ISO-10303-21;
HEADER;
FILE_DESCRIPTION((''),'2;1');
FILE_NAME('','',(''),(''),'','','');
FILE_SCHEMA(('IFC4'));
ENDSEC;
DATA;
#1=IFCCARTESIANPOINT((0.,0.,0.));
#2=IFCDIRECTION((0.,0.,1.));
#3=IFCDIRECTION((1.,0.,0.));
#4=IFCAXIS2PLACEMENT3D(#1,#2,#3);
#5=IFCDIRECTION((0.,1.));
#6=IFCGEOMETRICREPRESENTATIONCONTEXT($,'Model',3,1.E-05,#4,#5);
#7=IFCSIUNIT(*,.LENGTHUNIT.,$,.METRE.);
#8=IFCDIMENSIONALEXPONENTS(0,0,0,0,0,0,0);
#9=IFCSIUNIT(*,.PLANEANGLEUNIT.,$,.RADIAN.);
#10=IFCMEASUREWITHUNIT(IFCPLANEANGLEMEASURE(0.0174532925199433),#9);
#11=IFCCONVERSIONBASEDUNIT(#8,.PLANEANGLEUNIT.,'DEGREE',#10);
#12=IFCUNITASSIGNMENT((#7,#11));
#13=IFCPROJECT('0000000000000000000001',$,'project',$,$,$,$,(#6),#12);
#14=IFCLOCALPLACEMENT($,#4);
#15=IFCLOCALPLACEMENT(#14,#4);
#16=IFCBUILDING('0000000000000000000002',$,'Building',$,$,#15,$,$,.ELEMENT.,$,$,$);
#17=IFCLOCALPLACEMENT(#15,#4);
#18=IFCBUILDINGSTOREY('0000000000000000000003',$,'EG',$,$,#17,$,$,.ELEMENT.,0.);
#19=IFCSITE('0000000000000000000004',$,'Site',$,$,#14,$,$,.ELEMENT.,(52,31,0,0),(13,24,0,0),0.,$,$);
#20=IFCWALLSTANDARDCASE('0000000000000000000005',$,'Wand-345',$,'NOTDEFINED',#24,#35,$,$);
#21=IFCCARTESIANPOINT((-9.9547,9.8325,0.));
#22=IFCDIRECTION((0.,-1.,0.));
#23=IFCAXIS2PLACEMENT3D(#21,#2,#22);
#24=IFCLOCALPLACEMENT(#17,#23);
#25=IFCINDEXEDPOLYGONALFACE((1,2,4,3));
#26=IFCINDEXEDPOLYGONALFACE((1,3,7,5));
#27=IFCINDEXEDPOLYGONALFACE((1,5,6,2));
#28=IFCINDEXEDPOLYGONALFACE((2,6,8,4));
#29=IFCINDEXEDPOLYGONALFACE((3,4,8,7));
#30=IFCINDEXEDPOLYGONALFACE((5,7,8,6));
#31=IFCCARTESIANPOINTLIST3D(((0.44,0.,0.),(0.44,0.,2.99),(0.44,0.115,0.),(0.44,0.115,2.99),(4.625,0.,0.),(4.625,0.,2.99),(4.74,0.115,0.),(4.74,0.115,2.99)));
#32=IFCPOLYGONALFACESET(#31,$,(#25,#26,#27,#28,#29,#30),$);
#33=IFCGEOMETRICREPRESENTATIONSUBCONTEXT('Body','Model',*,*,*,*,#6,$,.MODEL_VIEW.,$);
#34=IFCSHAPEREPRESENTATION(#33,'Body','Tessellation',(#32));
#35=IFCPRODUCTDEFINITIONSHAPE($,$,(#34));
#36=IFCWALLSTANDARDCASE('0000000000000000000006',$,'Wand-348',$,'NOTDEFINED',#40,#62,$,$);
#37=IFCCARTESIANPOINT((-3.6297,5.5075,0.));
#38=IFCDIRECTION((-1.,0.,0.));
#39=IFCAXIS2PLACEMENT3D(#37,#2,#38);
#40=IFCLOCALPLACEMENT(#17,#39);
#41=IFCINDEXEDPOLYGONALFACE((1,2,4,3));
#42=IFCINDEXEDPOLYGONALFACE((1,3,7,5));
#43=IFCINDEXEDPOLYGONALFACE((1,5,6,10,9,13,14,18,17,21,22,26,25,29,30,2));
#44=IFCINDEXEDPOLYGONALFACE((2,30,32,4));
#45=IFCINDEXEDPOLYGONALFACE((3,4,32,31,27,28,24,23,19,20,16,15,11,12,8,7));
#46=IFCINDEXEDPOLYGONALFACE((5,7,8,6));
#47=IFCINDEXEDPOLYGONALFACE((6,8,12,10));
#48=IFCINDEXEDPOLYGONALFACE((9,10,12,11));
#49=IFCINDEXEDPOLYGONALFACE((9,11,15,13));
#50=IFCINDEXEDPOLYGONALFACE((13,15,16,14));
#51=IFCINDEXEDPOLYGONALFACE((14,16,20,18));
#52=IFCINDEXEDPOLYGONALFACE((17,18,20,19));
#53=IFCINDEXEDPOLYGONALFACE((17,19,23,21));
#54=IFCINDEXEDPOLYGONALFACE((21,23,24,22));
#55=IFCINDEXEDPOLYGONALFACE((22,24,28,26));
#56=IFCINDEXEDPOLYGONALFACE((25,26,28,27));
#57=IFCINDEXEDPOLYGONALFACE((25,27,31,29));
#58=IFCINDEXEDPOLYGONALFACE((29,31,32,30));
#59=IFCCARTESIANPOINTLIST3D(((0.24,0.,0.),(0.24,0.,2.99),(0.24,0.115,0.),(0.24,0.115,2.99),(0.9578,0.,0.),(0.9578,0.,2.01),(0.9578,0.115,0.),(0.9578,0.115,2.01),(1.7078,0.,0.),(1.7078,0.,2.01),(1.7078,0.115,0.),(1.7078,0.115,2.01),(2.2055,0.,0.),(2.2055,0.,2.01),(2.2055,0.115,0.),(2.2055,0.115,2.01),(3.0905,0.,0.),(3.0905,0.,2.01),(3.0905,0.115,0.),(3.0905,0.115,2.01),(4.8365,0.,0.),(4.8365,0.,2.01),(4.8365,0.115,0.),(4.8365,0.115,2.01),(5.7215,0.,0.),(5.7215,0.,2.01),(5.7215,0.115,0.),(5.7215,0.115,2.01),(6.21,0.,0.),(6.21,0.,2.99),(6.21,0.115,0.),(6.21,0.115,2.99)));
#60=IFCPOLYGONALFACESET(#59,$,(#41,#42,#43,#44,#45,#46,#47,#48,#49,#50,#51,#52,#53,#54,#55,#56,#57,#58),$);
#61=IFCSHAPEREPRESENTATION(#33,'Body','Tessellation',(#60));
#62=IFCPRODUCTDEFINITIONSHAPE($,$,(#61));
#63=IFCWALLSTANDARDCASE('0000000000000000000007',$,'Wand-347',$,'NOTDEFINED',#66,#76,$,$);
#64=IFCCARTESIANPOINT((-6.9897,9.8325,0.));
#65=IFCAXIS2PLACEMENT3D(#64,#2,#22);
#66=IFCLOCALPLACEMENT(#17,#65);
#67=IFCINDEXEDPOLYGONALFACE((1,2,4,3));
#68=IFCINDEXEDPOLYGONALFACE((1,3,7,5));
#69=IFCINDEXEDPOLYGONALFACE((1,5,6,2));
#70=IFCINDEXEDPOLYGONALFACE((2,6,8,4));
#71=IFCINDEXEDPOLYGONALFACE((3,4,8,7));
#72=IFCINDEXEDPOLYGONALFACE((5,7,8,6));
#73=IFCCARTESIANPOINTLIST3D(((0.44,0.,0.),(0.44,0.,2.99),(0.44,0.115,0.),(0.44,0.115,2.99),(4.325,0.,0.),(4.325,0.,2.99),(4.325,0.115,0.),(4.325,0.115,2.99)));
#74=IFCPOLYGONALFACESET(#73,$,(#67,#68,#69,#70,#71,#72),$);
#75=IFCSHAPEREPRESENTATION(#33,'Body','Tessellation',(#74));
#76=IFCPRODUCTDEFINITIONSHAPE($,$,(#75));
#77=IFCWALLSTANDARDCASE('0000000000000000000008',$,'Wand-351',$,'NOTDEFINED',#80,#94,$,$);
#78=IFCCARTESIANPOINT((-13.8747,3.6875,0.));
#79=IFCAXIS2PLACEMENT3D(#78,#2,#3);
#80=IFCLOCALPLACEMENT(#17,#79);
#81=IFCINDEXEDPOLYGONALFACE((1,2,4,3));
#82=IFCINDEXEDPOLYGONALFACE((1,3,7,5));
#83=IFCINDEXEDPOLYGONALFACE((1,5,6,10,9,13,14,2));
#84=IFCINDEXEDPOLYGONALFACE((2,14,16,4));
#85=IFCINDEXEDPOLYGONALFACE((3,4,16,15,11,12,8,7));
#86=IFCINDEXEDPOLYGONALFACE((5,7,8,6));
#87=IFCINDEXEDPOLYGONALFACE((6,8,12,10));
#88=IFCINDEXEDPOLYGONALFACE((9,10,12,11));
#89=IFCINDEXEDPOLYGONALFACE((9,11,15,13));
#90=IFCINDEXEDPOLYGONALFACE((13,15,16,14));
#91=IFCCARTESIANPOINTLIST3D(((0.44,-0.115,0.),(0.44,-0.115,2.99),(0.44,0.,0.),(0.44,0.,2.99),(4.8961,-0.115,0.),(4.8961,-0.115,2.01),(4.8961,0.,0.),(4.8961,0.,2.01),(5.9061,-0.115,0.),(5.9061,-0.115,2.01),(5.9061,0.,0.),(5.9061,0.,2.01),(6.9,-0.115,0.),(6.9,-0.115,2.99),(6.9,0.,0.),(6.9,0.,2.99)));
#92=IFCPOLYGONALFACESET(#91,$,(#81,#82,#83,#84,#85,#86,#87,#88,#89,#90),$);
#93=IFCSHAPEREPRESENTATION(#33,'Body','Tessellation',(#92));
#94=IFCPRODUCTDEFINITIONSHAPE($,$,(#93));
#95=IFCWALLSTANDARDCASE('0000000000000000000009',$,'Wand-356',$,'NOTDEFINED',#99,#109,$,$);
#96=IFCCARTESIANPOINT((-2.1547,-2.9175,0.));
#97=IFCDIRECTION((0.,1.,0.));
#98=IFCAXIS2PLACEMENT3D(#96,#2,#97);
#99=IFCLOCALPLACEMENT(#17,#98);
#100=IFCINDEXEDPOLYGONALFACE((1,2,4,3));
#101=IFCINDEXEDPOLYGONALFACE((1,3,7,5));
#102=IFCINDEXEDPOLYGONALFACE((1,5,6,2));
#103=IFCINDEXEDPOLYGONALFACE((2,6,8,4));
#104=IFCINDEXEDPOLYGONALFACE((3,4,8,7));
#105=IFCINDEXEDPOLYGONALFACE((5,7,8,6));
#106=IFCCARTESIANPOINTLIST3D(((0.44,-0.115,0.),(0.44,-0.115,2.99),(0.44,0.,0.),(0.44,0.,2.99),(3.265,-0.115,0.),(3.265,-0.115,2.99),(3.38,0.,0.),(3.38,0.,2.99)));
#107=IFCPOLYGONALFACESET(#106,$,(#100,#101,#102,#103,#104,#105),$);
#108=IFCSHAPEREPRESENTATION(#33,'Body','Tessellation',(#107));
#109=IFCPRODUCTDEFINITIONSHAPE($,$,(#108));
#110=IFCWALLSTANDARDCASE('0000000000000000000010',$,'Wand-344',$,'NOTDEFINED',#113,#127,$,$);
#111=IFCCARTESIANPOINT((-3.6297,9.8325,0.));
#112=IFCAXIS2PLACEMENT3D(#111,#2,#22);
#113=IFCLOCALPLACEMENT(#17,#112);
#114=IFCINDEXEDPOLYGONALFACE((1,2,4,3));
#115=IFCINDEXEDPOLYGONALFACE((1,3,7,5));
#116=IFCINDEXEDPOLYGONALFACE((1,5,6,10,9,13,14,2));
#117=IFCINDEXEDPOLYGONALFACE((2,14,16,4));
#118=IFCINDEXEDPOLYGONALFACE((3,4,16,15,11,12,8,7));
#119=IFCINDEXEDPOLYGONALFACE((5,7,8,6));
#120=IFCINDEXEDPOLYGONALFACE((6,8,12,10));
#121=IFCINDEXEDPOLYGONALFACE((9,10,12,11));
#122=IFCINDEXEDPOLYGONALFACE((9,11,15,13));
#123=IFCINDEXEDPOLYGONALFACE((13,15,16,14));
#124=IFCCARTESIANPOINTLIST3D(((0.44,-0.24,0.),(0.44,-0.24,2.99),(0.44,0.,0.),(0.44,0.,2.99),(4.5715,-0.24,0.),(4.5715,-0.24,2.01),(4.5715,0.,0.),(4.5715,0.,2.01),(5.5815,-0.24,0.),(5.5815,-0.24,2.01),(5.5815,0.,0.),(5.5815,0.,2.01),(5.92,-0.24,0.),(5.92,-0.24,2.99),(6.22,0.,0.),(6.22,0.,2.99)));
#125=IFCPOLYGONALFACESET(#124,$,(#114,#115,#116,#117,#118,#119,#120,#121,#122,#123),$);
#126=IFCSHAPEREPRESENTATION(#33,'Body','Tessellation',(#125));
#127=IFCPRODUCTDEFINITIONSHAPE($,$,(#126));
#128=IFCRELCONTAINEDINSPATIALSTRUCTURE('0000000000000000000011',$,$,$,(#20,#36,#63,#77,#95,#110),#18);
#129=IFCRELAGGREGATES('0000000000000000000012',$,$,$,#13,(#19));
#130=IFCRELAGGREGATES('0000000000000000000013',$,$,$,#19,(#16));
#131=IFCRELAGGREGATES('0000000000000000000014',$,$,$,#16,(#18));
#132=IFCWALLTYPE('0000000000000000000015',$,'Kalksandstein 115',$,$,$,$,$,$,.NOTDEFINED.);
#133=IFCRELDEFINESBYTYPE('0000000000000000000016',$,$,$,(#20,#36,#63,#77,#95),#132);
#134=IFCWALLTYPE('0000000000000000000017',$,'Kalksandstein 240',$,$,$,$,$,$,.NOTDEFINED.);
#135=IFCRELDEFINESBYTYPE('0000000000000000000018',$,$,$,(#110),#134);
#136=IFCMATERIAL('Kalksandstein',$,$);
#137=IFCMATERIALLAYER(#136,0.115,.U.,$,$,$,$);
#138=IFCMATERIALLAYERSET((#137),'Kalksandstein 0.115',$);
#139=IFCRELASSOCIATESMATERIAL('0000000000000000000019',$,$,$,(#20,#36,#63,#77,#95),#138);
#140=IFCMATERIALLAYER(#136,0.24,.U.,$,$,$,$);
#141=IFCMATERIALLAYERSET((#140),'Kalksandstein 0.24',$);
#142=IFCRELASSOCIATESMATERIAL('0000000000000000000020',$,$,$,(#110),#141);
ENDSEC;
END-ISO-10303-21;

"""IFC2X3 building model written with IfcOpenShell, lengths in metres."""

from ifc_helpers import new_model, entity, si_unit, converted_unit, direction, frame, origin_with_axes, origin_2d_with_axis, place, context, subcontext, project, spatial, polyline, rectangle, outline, extrude, material, layer, layer_set, layer_usage, type_object, element, save


model = new_model("IFC2X3")

# Units and contexts
model_context = context("Model", 3, precision=1e-05, world=origin_with_axes(), true_north=direction((0.0, 1.0)))
body_context = subcontext(model_context, "Body", "Model", "MODEL_VIEW")
ifc_project = project(units=[si_unit("LENGTHUNIT", "METRE"), converted_unit("PLANEANGLEUNIT", "DEGREE", entity("IfcPlaneAngleMeasure", 0.0174532925199433), si_unit("PLANEANGLEUNIT", "RADIAN"), dimensions=[0, 0, 0, 0, 0, 0, 0])], contexts=[model_context])

# Site, building, storey
site_placement = place(None, origin_with_axes())
site = spatial("IfcSite", under=ifc_project, at=site_placement, Name="Site", CompositionType="ELEMENT", RefLatitude=(52, 31, 0, 0), RefLongitude=(13, 24, 0, 0), RefElevation=0.0)
building_placement = place(site_placement, origin_with_axes())
building = spatial("IfcBuilding", under=site, at=building_placement, Name="Building", CompositionType="ELEMENT")
storey_placement = place(building_placement, origin_with_axes())
storey = spatial("IfcBuildingStorey", under=building, at=storey_placement, Name="EG", CompositionType="ELEMENT", Elevation=0.0)

# Shared definitions
ifc_material_1 = material(Name="Kalksandstein")

# Wall
ifc_layer_1 = layer(ifc_material_1, 0.115, ventilated="UNKNOWN")
ifc_layer_set_1 = layer_set([ifc_layer_1], Name="Kalksandstein 0.115")
ifc_layer_usage_1 = layer_usage(ifc_layer_set_1, "AXIS2", "NEGATIVE", 0.115)
wall_type_1 = type_object("IfcWallType", Name="Kalksandstein 115", PredefinedType="NOTDEFINED")
wall_1_placement = place(storey_placement, frame((-9.9547, 9.8325, 0.0), z_axis=(0.0, 0.0, 1.0), x_axis=(0.0, -1.0, 0.0)))
element("IfcWallStandardCase", 1, at=wall_1_placement, inside=storey, type_object=wall_type_1, material=ifc_layer_usage_1, Name="Wand-345", ObjectType="NOTDEFINED", context=body_context, shape_type="SweptSolid", body=[
    extrude(outline(polyline([(0.44, 0.0), (4.625, 0.0), (4.74, 0.115), (0.44, 0.115), (0.44, 0.0)])), origin_with_axes(), (0.0, 0.0, 1.0), 2.99),
])

# Wall, openings
ifc_layer_usage_2 = layer_usage(ifc_layer_set_1, "AXIS2", "NEGATIVE", 0.115)
wall_2_placement = place(storey_placement, frame((-3.6297, 5.5075, 0.0), z_axis=(0.0, 0.0, 1.0), x_axis=(-1.0, 0.0, 0.0)))
wall_2 = element("IfcWallStandardCase", 2, at=wall_2_placement, inside=storey, type_object=wall_type_1, material=ifc_layer_usage_2, Name="Wand-348", ObjectType="NOTDEFINED", context=body_context, shape_type="SweptSolid", body=[
    extrude(outline(polyline([(0.24, 0.0), (6.21, 0.0), (6.21, 0.115), (0.24, 0.115), (0.24, 0.0)])), origin_with_axes(), (0.0, 0.0, 1.0), 2.99),
])
opening_1_placement = place(wall_2_placement, frame((2.648, 0.0, 0.0), z_axis=(0.0, 0.0, 1.0), x_axis=(1.0, 0.0, 0.0)))
element("IfcOpeningElement", 3, at=opening_1_placement, cuts=wall_2, context=body_context, shape_type="SweptSolid", body=[
    extrude(rectangle(XDim=0.885, YDim=2.01, at=origin_2d_with_axis()), frame((0.0, -0.115, 1.005), z_axis=(0.0, -1.0, 0.0), x_axis=(-1.0, 0.0, 0.0)), (0.0, 0.0, -1.0), 0.345),
])
opening_2_placement = place(wall_2_placement, frame((5.279, 0.0, 0.0), z_axis=(0.0, 0.0, 1.0), x_axis=(1.0, 0.0, 0.0)))
element("IfcOpeningElement", 4, at=opening_2_placement, cuts=wall_2, context=body_context, shape_type="SweptSolid", body=[
    extrude(rectangle(XDim=0.885, YDim=2.01, at=origin_2d_with_axis()), frame((0.0, 0.115, 1.005), z_axis=(0.0, 1.0, 0.0), x_axis=(1.0, 0.0, 0.0)), (0.0, 0.0, -1.0), 0.345),
])
opening_3_placement = place(wall_2_placement, frame((1.3328, 0.0, 0.0), z_axis=(0.0, 0.0, 1.0), x_axis=(1.0, 0.0, 0.0)))
element("IfcOpeningElement", 5, at=opening_3_placement, cuts=wall_2, context=body_context, shape_type="SweptSolid", body=[
    extrude(rectangle(XDim=0.75, YDim=2.01, at=origin_2d_with_axis()), frame((0.0, -0.115, 1.005), z_axis=(0.0, -1.0, 0.0), x_axis=(-1.0, 0.0, 0.0)), (0.0, 0.0, -1.0), 0.345),
])

# Wall
ifc_layer_usage_3 = layer_usage(ifc_layer_set_1, "AXIS2", "NEGATIVE", 0.115)
wall_3_placement = place(storey_placement, frame((-6.9897, 9.8325, 0.0), z_axis=(0.0, 0.0, 1.0), x_axis=(0.0, -1.0, 0.0)))
element("IfcWallStandardCase", 6, at=wall_3_placement, inside=storey, type_object=wall_type_1, material=ifc_layer_usage_3, Name="Wand-347", ObjectType="NOTDEFINED", context=body_context, shape_type="SweptSolid", body=[
    extrude(outline(polyline([(0.44, 0.0), (4.325, 0.0), (4.325, 0.115), (0.44, 0.115), (0.44, 0.0)])), origin_with_axes(), (0.0, 0.0, 1.0), 2.99),
])

# Wall, opening
ifc_layer_usage_4 = layer_usage(ifc_layer_set_1, "AXIS2", "POSITIVE", -0.115)
wall_4_placement = place(storey_placement, frame((-13.8747, 3.6875, 0.0), z_axis=(0.0, 0.0, 1.0), x_axis=(1.0, 0.0, 0.0)))
wall_4 = element("IfcWallStandardCase", 7, at=wall_4_placement, inside=storey, type_object=wall_type_1, material=ifc_layer_usage_4, Name="Wand-351", ObjectType="NOTDEFINED", context=body_context, shape_type="SweptSolid", body=[
    extrude(outline(polyline([(0.44, -0.115), (6.9, -0.115), (6.9, 0.0), (0.44, 0.0), (0.44, -0.115)])), origin_with_axes(), (0.0, 0.0, 1.0), 2.99),
])
opening_4_placement = place(wall_4_placement, frame((5.4011, 0.0, 0.0), z_axis=(0.0, 0.0, 1.0), x_axis=(1.0, 0.0, 0.0)))
element("IfcOpeningElement", 8, at=opening_4_placement, cuts=wall_4, context=body_context, shape_type="SweptSolid", body=[
    extrude(rectangle(XDim=1.01, YDim=2.01, at=origin_2d_with_axis()), frame((0.0, 0.115, 1.005), z_axis=(0.0, 1.0, 0.0), x_axis=(1.0, 0.0, 0.0)), (0.0, 0.0, -1.0), 0.345),
])

# Wall
ifc_layer_usage_5 = layer_usage(ifc_layer_set_1, "AXIS2", "POSITIVE", -0.115)
wall_5_placement = place(storey_placement, frame((-2.1547, -2.9175, 0.0), z_axis=(0.0, 0.0, 1.0), x_axis=(0.0, 1.0, 0.0)))
element("IfcWallStandardCase", 9, at=wall_5_placement, inside=storey, type_object=wall_type_1, material=ifc_layer_usage_5, Name="Wand-356", ObjectType="NOTDEFINED", context=body_context, shape_type="SweptSolid", body=[
    extrude(outline(polyline([(0.44, -0.115), (3.265, -0.115), (3.38, 0.0), (0.44, 0.0), (0.44, -0.115)])), origin_with_axes(), (0.0, 0.0, 1.0), 2.99),
])

# Wall, opening
ifc_layer_2 = layer(ifc_material_1, 0.24, ventilated="UNKNOWN")
ifc_layer_set_2 = layer_set([ifc_layer_2], Name="Kalksandstein 0.24")
ifc_layer_usage_6 = layer_usage(ifc_layer_set_2, "AXIS2", "POSITIVE", -0.24)
wall_type_2 = type_object("IfcWallType", Name="Kalksandstein 240", PredefinedType="NOTDEFINED")
wall_6_placement = place(storey_placement, frame((-3.6297, 9.8325, 0.0), z_axis=(0.0, 0.0, 1.0), x_axis=(0.0, -1.0, 0.0)))
wall_6 = element("IfcWallStandardCase", 10, at=wall_6_placement, inside=storey, type_object=wall_type_2, material=ifc_layer_usage_6, Name="Wand-344", ObjectType="NOTDEFINED", context=body_context, shape_type="SweptSolid", body=[
    extrude(outline(polyline([(0.44, -0.24), (5.92, -0.24), (6.22, 0.0), (0.44, 0.0), (0.44, -0.24)])), origin_with_axes(), (0.0, 0.0, 1.0), 2.99),
])
opening_5_placement = place(wall_6_placement, frame((5.0765, 0.0, 0.0), z_axis=(0.0, 0.0, 1.0), x_axis=(1.0, 0.0, 0.0)))
element("IfcOpeningElement", 11, at=opening_5_placement, cuts=wall_6, context=body_context, shape_type="SweptSolid", body=[
    extrude(rectangle(XDim=1.01, YDim=2.01, at=origin_2d_with_axis()), frame((0.0, 0.24, 1.005), z_axis=(0.0, -1.0, 0.0), x_axis=(-1.0, 0.0, 0.0)), (0.0, 0.0, 1.0), 0.72),
])

save(model, "model.ifc")
